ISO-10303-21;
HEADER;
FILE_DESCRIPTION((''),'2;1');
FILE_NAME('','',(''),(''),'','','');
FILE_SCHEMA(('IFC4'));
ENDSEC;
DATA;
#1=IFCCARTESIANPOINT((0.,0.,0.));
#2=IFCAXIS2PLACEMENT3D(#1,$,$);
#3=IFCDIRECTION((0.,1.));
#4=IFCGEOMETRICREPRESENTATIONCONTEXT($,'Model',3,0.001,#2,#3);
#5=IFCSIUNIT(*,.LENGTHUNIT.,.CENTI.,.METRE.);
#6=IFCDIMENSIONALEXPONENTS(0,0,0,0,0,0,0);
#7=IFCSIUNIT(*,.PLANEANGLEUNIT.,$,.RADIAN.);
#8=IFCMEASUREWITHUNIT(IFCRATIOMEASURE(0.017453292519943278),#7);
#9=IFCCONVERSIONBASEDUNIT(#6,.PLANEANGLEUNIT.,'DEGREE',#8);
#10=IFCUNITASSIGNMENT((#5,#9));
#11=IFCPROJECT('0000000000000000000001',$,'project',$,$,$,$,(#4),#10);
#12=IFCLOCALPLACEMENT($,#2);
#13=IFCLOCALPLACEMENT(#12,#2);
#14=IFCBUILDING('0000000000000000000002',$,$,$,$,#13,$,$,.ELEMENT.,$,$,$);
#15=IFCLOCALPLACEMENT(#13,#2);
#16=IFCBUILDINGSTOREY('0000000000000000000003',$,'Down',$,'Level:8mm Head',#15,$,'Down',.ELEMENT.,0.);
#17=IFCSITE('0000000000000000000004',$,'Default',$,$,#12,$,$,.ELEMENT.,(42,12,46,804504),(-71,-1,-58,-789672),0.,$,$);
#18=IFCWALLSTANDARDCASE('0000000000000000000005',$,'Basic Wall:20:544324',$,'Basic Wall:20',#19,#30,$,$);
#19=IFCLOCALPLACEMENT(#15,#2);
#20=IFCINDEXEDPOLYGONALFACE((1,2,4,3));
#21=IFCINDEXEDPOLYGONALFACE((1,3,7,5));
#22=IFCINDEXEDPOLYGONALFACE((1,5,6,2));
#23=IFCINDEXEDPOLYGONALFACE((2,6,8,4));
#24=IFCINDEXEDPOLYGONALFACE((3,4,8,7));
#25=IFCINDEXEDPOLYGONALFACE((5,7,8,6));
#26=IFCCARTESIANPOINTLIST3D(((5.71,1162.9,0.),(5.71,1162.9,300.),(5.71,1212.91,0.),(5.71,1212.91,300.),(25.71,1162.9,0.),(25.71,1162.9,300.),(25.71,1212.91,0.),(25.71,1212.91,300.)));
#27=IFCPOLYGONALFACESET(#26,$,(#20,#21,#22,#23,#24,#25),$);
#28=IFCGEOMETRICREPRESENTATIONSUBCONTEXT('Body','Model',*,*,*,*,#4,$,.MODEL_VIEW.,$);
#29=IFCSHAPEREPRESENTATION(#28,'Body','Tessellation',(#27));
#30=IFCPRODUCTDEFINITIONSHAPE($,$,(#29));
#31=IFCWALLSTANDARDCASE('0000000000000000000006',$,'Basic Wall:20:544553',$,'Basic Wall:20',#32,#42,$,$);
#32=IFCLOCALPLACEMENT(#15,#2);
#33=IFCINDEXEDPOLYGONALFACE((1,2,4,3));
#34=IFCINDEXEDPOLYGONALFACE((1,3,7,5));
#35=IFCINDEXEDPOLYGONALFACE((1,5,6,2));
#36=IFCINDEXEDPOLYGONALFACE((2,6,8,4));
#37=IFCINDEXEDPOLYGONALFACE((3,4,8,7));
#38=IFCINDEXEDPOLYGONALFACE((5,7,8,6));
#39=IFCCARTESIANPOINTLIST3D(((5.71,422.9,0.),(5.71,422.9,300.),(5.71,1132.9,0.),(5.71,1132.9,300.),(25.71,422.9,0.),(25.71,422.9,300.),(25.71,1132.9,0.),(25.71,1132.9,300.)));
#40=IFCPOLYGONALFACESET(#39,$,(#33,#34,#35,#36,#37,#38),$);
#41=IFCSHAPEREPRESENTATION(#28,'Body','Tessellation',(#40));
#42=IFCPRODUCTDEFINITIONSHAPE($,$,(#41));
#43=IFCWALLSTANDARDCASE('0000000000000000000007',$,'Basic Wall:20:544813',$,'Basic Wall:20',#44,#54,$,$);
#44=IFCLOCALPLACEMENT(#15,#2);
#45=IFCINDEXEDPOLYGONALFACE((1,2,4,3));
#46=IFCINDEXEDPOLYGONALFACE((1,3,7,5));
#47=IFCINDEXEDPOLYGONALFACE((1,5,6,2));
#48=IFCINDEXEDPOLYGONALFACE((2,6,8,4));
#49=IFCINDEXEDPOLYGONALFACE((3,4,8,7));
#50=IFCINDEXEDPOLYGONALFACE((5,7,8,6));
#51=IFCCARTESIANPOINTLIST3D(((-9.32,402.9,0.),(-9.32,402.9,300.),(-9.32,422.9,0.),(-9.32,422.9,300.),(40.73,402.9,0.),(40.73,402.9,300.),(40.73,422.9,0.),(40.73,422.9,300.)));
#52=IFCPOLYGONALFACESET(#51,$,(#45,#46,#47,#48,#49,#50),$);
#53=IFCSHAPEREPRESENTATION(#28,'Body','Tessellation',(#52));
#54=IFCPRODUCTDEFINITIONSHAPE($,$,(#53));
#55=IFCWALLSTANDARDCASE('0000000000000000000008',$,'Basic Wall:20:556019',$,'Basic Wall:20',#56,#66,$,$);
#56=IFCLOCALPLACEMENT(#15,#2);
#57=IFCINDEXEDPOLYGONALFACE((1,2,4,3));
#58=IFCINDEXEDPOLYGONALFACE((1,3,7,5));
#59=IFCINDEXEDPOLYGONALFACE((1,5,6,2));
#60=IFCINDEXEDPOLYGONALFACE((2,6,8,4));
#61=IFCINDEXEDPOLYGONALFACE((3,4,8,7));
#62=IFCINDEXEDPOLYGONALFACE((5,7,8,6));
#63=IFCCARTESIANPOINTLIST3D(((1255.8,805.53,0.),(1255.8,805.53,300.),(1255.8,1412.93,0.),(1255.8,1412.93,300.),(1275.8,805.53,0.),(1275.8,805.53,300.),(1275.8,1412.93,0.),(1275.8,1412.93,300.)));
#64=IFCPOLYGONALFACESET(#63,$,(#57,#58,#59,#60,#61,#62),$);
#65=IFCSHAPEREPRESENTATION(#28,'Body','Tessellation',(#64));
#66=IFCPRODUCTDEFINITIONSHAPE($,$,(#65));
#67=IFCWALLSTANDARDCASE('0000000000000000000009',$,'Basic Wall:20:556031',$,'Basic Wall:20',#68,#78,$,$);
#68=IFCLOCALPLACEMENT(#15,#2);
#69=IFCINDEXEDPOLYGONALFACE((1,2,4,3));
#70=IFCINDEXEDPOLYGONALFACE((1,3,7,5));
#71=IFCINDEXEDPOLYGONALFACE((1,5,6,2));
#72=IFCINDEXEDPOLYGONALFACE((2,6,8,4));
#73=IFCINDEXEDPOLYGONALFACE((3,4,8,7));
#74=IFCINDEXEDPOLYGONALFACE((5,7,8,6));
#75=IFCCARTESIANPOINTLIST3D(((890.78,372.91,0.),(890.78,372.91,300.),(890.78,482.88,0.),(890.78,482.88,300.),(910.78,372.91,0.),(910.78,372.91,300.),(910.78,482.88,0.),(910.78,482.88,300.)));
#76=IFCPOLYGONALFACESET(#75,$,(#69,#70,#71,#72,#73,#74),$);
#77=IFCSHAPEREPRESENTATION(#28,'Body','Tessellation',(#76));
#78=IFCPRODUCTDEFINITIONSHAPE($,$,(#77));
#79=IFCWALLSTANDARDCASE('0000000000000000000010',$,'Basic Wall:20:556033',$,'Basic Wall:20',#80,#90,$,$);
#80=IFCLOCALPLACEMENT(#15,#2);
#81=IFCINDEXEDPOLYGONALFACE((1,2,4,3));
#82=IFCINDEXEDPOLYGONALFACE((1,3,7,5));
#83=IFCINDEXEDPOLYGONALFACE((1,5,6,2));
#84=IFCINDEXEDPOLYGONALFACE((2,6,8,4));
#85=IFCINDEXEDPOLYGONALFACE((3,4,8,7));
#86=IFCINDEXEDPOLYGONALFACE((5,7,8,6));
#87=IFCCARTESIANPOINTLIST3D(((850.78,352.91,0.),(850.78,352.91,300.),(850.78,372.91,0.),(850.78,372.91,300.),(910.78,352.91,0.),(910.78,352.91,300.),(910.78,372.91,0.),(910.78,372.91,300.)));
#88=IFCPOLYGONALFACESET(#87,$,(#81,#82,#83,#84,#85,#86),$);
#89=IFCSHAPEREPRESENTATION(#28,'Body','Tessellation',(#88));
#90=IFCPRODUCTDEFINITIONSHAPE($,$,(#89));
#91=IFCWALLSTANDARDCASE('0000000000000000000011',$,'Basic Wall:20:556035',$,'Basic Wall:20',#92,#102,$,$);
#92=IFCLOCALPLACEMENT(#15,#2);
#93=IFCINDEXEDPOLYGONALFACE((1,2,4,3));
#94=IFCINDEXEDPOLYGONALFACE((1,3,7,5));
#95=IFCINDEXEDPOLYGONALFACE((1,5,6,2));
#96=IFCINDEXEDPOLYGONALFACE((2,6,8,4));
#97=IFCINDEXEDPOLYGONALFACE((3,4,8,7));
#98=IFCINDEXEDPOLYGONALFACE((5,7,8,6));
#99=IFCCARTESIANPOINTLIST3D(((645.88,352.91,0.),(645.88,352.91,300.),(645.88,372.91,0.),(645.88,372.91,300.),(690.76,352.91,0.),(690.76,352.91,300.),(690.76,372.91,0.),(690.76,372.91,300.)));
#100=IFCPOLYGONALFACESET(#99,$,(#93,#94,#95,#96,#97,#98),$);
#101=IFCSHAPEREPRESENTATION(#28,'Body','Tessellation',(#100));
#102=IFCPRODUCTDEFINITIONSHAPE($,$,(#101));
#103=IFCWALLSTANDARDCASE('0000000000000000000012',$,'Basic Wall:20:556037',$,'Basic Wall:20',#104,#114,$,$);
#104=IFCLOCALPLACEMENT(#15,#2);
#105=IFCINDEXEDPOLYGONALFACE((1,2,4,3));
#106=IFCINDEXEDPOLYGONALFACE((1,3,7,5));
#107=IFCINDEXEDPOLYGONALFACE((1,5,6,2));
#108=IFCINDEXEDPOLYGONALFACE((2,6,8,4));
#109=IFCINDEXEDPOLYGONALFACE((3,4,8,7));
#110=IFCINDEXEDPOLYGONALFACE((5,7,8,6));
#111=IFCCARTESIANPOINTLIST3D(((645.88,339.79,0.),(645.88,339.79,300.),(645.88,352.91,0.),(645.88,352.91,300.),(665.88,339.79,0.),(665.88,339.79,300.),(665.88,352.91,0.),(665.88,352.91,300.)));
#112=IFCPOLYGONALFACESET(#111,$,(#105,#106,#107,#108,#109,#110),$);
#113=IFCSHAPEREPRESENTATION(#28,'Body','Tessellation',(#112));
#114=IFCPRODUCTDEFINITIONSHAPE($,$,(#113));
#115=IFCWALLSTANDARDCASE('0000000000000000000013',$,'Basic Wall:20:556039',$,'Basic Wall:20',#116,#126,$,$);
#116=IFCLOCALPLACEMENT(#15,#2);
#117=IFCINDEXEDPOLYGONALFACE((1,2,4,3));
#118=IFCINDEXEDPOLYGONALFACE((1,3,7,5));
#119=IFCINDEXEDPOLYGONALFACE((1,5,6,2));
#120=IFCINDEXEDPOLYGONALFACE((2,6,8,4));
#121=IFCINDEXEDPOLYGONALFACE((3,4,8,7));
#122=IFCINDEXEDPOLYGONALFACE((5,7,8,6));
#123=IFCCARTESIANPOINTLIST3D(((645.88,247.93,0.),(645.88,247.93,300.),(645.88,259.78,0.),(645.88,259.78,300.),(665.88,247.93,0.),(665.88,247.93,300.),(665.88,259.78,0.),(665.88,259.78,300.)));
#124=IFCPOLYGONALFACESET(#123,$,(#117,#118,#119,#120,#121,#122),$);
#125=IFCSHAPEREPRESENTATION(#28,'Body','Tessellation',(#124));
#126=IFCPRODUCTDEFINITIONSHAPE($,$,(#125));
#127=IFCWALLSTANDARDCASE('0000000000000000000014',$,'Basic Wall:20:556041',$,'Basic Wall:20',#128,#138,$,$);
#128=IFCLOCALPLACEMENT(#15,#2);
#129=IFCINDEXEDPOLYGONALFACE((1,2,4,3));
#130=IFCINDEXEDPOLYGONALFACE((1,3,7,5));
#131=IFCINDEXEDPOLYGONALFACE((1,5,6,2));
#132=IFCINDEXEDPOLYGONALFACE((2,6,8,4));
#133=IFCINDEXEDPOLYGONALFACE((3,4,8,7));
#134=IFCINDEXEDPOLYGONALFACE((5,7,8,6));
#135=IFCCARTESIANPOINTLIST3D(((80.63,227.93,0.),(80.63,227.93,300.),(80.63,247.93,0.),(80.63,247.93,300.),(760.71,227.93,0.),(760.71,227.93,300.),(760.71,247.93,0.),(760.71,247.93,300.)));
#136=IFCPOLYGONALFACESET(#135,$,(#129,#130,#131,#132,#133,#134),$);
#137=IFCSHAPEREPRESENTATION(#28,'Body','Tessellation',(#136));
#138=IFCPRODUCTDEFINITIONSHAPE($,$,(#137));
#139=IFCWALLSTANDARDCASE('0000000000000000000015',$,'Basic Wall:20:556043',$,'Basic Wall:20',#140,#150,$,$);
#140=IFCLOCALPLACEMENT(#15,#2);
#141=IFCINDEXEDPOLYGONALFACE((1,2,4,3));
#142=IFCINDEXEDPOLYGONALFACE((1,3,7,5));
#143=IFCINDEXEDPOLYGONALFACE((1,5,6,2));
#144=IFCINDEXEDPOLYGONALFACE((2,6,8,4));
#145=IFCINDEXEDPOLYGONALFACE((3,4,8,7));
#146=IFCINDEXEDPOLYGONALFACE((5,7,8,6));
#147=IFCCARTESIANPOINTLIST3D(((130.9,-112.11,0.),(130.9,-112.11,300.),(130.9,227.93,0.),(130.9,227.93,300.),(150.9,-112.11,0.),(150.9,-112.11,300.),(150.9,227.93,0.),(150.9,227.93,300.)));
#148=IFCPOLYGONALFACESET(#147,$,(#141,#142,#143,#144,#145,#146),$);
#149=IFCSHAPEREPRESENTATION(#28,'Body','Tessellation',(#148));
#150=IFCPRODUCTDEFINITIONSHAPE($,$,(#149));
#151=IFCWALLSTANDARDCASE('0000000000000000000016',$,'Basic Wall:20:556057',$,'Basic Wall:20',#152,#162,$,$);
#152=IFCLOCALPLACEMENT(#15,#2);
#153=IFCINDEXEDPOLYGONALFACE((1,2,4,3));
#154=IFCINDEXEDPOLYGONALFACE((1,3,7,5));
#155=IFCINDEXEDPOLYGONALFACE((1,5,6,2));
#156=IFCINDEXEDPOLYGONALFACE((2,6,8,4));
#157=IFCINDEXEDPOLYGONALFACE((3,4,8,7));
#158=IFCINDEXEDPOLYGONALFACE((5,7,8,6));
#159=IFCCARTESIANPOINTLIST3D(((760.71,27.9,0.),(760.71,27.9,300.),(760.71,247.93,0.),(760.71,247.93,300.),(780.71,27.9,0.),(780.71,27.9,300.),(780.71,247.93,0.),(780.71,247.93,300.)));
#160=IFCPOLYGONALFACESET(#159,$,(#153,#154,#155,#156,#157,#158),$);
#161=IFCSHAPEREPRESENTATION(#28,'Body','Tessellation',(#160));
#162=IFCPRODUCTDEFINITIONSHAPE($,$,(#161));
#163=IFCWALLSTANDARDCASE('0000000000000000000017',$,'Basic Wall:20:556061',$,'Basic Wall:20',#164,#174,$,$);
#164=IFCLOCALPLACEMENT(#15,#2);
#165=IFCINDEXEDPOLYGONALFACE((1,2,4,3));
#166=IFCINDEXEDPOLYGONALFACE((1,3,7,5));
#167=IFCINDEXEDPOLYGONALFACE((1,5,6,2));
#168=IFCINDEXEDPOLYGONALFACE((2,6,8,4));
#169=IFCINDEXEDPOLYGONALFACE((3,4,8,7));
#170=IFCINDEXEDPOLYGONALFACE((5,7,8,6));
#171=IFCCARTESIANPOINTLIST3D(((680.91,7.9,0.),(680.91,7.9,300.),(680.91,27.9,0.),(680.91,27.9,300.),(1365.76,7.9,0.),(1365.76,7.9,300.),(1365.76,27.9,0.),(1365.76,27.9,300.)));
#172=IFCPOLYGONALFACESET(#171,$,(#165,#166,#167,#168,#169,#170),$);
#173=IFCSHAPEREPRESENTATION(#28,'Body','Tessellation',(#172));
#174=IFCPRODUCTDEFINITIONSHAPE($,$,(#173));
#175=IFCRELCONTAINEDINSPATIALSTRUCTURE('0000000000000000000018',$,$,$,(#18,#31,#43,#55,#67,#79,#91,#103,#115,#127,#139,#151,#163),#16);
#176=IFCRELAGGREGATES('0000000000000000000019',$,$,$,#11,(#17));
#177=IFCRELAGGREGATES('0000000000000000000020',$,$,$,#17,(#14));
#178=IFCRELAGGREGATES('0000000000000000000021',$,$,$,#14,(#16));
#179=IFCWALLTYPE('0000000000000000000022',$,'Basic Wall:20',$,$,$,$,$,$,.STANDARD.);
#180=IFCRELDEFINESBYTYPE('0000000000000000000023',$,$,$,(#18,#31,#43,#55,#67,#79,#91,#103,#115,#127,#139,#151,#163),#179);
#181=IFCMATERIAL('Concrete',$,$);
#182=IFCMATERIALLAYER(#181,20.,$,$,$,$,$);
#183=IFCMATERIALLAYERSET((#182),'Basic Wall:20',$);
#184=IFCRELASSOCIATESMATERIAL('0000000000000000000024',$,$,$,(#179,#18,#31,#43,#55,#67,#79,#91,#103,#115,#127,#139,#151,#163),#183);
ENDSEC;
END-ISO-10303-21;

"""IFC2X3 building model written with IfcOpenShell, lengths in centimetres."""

from ifc_helpers import new_model, entity, si_unit, converted_unit, direction, frame, frame_2d, origin, place, context, subcontext, project, spatial, rectangle, extrude, material, layer, layer_set, layer_usage, type_object, element, save


model = new_model("IFC2X3")

# Units and contexts
model_context = context("Model", 3, precision=0.001, world=origin(), true_north=direction((0.0, 1.0)))
body_context = subcontext(model_context, "Body", "Model", "MODEL_VIEW")
ifc_project = project(units=[si_unit("LENGTHUNIT", "METRE", prefix="CENTI"), converted_unit("PLANEANGLEUNIT", "DEGREE", entity("IfcRatioMeasure", 0.017453292519943278), si_unit("PLANEANGLEUNIT", "RADIAN"), dimensions=[0, 0, 0, 0, 0, 0, 0])], contexts=[model_context])

# Site, building, storey
site_placement = place(None, origin())
site = spatial("IfcSite", under=ifc_project, at=site_placement, Name="Default", CompositionType="ELEMENT", RefLatitude=(42, 12, 46, 804504), RefLongitude=(-71, -1, -58, -789672), RefElevation=0.0)
building_placement = place(site_placement, origin())
building = spatial("IfcBuilding", under=site, at=building_placement, CompositionType="ELEMENT")
storey_placement = place(building_placement, origin())
storey = spatial("IfcBuildingStorey", under=building, at=storey_placement, Name="Down", ObjectType="Level:8mm Head", LongName="Down", CompositionType="ELEMENT", Elevation=0.0)

# Walls
ifc_material = material(Name="Concrete")
ifc_layer_1 = layer(ifc_material, 20.0)
ifc_layer_set_1 = layer_set([ifc_layer_1], Name="Basic Wall:20")
ifc_layer_usage_1 = layer_usage(ifc_layer_set_1, "AXIS2", "POSITIVE", -10.0)
wall_type_1 = type_object("IfcWallType", Name="Basic Wall:20", PredefinedType="STANDARD", material=ifc_layer_set_1)
wall_1_placement = place(storey_placement, frame((15.71, 1212.91, 0.0), z_axis=(0.0, 0.0, 1.0), x_axis=(0.0, -1.0, 0.0)))
element("IfcWallStandardCase", 1, at=wall_1_placement, inside=storey, type_object=wall_type_1, material=ifc_layer_usage_1, Name="Basic Wall:20:544324", ObjectType="Basic Wall:20", context=body_context, shape_type="SweptSolid", body=[
    extrude(rectangle(XDim=50.01, YDim=20.0, at=frame_2d((25.0, 0.0), x_axis=(-1.0, 0.0))), origin(), (0.0, 0.0, 1.0), 300.0),
])
ifc_layer_usage_2 = layer_usage(ifc_layer_set_1, "AXIS2", "POSITIVE", -10.0)
wall_2_placement = place(storey_placement, frame((15.71, 1132.9, 0.0), z_axis=(0.0, 0.0, 1.0), x_axis=(0.0, -1.0, 0.0)))
element("IfcWallStandardCase", 2, at=wall_2_placement, inside=storey, type_object=wall_type_1, material=ifc_layer_usage_2, Name="Basic Wall:20:544553", ObjectType="Basic Wall:20", context=body_context, shape_type="SweptSolid", body=[
    extrude(rectangle(XDim=710.0, YDim=20.0, at=frame_2d((355.0, 0.0), x_axis=(-1.0, 0.0))), origin(), (0.0, 0.0, 1.0), 300.0),
])
ifc_layer_usage_3 = layer_usage(ifc_layer_set_1, "AXIS2", "NEGATIVE", 10.0)
wall_3_placement = place(storey_placement, frame((40.73, 412.9, 0.0), z_axis=(0.0, 0.0, 1.0), x_axis=(-1.0, 0.0, 0.0)))
element("IfcWallStandardCase", 3, at=wall_3_placement, inside=storey, type_object=wall_type_1, material=ifc_layer_usage_3, Name="Basic Wall:20:544813", ObjectType="Basic Wall:20", context=body_context, shape_type="SweptSolid", body=[
    extrude(rectangle(XDim=50.06, YDim=20.0, at=frame_2d((25.03, 0.0), x_axis=(-1.0, 0.0))), origin(), (0.0, 0.0, 1.0), 300.0),
])
ifc_layer_usage_4 = layer_usage(ifc_layer_set_1, "AXIS2", "NEGATIVE", 10.0)
wall_4_placement = place(storey_placement, frame((1265.8, 1412.93, 0.0), z_axis=(0.0, 0.0, 1.0), x_axis=(0.0, -1.0, 0.0)))
element("IfcWallStandardCase", 4, at=wall_4_placement, inside=storey, type_object=wall_type_1, material=ifc_layer_usage_4, Name="Basic Wall:20:556019", ObjectType="Basic Wall:20", context=body_context, shape_type="SweptSolid", body=[
    extrude(rectangle(XDim=607.41, YDim=20.0, at=frame_2d((303.7, 0.0), x_axis=(-1.0, 0.0))), origin(), (0.0, 0.0, 1.0), 300.0),
])
ifc_layer_usage_5 = layer_usage(ifc_layer_set_1, "AXIS2", "POSITIVE", -10.0)
wall_5_placement = place(storey_placement, frame((900.78, 482.88, 0.0), z_axis=(0.0, 0.0, 1.0), x_axis=(0.0, -1.0, 0.0)))
element("IfcWallStandardCase", 5, at=wall_5_placement, inside=storey, type_object=wall_type_1, material=ifc_layer_usage_5, Name="Basic Wall:20:556031", ObjectType="Basic Wall:20", context=body_context, shape_type="SweptSolid", body=[
    extrude(rectangle(XDim=109.96, YDim=20.0, at=frame_2d((54.98, 0.0), x_axis=(-1.0, 0.0))), origin(), (0.0, 0.0, 1.0), 300.0),
])
ifc_layer_usage_6 = layer_usage(ifc_layer_set_1, "AXIS2", "NEGATIVE", 10.0)
wall_6_placement = place(storey_placement, frame((910.78, 362.91, 0.0), z_axis=(0.0, 0.0, 1.0), x_axis=(-1.0, 0.0, 0.0)))
element("IfcWallStandardCase", 6, at=wall_6_placement, inside=storey, type_object=wall_type_1, material=ifc_layer_usage_6, Name="Basic Wall:20:556033", ObjectType="Basic Wall:20", context=body_context, shape_type="SweptSolid", body=[
    extrude(rectangle(XDim=60.0, YDim=20.0, at=frame_2d((30.0, 0.0), x_axis=(-1.0, 0.0))), origin(), (0.0, 0.0, 1.0), 300.0),
])
ifc_layer_usage_7 = layer_usage(ifc_layer_set_1, "AXIS2", "NEGATIVE", 10.0)
wall_7_placement = place(storey_placement, frame((690.76, 362.91, 0.0), z_axis=(0.0, 0.0, 1.0), x_axis=(-1.0, 0.0, 0.0)))
element("IfcWallStandardCase", 7, at=wall_7_placement, inside=storey, type_object=wall_type_1, material=ifc_layer_usage_7, Name="Basic Wall:20:556035", ObjectType="Basic Wall:20", context=body_context, shape_type="SweptSolid", body=[
    extrude(rectangle(XDim=44.87, YDim=20.0, at=frame_2d((22.44, 0.0), x_axis=(-1.0, 0.0))), origin(), (0.0, 0.0, 1.0), 300.0),
])
ifc_layer_usage_8 = layer_usage(ifc_layer_set_1, "AXIS2", "POSITIVE", -10.0)
wall_8_placement = place(storey_placement, frame((655.88, 352.91, 0.0), z_axis=(0.0, 0.0, 1.0), x_axis=(0.0, -1.0, 0.0)))
element("IfcWallStandardCase", 8, at=wall_8_placement, inside=storey, type_object=wall_type_1, material=ifc_layer_usage_8, Name="Basic Wall:20:556037", ObjectType="Basic Wall:20", context=body_context, shape_type="SweptSolid", body=[
    extrude(rectangle(XDim=13.12, YDim=20.0, at=frame_2d((6.56, 0.0), x_axis=(-1.0, 0.0))), origin(), (0.0, 0.0, 1.0), 300.0),
])
ifc_layer_usage_9 = layer_usage(ifc_layer_set_1, "AXIS2", "POSITIVE", -10.0)
wall_9_placement = place(storey_placement, frame((655.88, 259.78, 0.0), z_axis=(0.0, 0.0, 1.0), x_axis=(0.0, -1.0, 0.0)))
element("IfcWallStandardCase", 9, at=wall_9_placement, inside=storey, type_object=wall_type_1, material=ifc_layer_usage_9, Name="Basic Wall:20:556039", ObjectType="Basic Wall:20", context=body_context, shape_type="SweptSolid", body=[
    extrude(rectangle(XDim=11.85, YDim=20.0, at=frame_2d((5.93, 0.0), x_axis=(-1.0, 0.0))), origin(), (0.0, 0.0, 1.0), 300.0),
])
ifc_layer_usage_10 = layer_usage(ifc_layer_set_1, "AXIS2", "POSITIVE", -10.0)
wall_10_placement = place(storey_placement, frame((760.71, 237.93, 0.0), z_axis=(0.0, 0.0, 1.0), x_axis=(-1.0, 0.0, 0.0)))
element("IfcWallStandardCase", 10, at=wall_10_placement, inside=storey, type_object=wall_type_1, material=ifc_layer_usage_10, Name="Basic Wall:20:556041", ObjectType="Basic Wall:20", context=body_context, shape_type="SweptSolid", body=[
    extrude(rectangle(XDim=680.08, YDim=20.0, at=frame_2d((340.04, 0.0), x_axis=(-1.0, 0.0))), origin(), (0.0, 0.0, 1.0), 300.0),
])
ifc_layer_usage_11 = layer_usage(ifc_layer_set_1, "AXIS2", "POSITIVE", -10.0)
wall_11_placement = place(storey_placement, frame((140.9, 227.93, 0.0), z_axis=(0.0, 0.0, 1.0), x_axis=(0.0, -1.0, 0.0)))
element("IfcWallStandardCase", 11, at=wall_11_placement, inside=storey, type_object=wall_type_1, material=ifc_layer_usage_11, Name="Basic Wall:20:556043", ObjectType="Basic Wall:20", context=body_context, shape_type="SweptSolid", body=[
    extrude(rectangle(XDim=340.04, YDim=20.0, at=frame_2d((170.02, 0.0), x_axis=(-1.0, 0.0))), origin(), (0.0, 0.0, 1.0), 300.0),
])
ifc_layer_usage_12 = layer_usage(ifc_layer_set_1, "AXIS2", "NEGATIVE", 10.0)
wall_12_placement = place(storey_placement, frame((770.71, 247.93, 0.0), z_axis=(0.0, 0.0, 1.0), x_axis=(0.0, -1.0, 0.0)))
element("IfcWallStandardCase", 12, at=wall_12_placement, inside=storey, type_object=wall_type_1, material=ifc_layer_usage_12, Name="Basic Wall:20:556057", ObjectType="Basic Wall:20", context=body_context, shape_type="SweptSolid", body=[
    extrude(rectangle(XDim=220.03, YDim=20.0, at=frame_2d((110.01, 0.0), x_axis=(-1.0, 0.0))), origin(), (0.0, 0.0, 1.0), 300.0),
])
ifc_layer_usage_13 = layer_usage(ifc_layer_set_1, "AXIS2", "POSITIVE", -10.0)
wall_13_placement = place(storey_placement, frame((680.91, 17.9, 0.0)))
element("IfcWallStandardCase", 13, at=wall_13_placement, inside=storey, type_object=wall_type_1, material=ifc_layer_usage_13, Name="Basic Wall:20:556061", ObjectType="Basic Wall:20", context=body_context, shape_type="SweptSolid", body=[
    extrude(rectangle(XDim=684.84, YDim=20.0, at=frame_2d((342.42, 0.0), x_axis=(-1.0, 0.0))), origin(), (0.0, 0.0, 1.0), 300.0),
])

save(model, "model.ifc")
